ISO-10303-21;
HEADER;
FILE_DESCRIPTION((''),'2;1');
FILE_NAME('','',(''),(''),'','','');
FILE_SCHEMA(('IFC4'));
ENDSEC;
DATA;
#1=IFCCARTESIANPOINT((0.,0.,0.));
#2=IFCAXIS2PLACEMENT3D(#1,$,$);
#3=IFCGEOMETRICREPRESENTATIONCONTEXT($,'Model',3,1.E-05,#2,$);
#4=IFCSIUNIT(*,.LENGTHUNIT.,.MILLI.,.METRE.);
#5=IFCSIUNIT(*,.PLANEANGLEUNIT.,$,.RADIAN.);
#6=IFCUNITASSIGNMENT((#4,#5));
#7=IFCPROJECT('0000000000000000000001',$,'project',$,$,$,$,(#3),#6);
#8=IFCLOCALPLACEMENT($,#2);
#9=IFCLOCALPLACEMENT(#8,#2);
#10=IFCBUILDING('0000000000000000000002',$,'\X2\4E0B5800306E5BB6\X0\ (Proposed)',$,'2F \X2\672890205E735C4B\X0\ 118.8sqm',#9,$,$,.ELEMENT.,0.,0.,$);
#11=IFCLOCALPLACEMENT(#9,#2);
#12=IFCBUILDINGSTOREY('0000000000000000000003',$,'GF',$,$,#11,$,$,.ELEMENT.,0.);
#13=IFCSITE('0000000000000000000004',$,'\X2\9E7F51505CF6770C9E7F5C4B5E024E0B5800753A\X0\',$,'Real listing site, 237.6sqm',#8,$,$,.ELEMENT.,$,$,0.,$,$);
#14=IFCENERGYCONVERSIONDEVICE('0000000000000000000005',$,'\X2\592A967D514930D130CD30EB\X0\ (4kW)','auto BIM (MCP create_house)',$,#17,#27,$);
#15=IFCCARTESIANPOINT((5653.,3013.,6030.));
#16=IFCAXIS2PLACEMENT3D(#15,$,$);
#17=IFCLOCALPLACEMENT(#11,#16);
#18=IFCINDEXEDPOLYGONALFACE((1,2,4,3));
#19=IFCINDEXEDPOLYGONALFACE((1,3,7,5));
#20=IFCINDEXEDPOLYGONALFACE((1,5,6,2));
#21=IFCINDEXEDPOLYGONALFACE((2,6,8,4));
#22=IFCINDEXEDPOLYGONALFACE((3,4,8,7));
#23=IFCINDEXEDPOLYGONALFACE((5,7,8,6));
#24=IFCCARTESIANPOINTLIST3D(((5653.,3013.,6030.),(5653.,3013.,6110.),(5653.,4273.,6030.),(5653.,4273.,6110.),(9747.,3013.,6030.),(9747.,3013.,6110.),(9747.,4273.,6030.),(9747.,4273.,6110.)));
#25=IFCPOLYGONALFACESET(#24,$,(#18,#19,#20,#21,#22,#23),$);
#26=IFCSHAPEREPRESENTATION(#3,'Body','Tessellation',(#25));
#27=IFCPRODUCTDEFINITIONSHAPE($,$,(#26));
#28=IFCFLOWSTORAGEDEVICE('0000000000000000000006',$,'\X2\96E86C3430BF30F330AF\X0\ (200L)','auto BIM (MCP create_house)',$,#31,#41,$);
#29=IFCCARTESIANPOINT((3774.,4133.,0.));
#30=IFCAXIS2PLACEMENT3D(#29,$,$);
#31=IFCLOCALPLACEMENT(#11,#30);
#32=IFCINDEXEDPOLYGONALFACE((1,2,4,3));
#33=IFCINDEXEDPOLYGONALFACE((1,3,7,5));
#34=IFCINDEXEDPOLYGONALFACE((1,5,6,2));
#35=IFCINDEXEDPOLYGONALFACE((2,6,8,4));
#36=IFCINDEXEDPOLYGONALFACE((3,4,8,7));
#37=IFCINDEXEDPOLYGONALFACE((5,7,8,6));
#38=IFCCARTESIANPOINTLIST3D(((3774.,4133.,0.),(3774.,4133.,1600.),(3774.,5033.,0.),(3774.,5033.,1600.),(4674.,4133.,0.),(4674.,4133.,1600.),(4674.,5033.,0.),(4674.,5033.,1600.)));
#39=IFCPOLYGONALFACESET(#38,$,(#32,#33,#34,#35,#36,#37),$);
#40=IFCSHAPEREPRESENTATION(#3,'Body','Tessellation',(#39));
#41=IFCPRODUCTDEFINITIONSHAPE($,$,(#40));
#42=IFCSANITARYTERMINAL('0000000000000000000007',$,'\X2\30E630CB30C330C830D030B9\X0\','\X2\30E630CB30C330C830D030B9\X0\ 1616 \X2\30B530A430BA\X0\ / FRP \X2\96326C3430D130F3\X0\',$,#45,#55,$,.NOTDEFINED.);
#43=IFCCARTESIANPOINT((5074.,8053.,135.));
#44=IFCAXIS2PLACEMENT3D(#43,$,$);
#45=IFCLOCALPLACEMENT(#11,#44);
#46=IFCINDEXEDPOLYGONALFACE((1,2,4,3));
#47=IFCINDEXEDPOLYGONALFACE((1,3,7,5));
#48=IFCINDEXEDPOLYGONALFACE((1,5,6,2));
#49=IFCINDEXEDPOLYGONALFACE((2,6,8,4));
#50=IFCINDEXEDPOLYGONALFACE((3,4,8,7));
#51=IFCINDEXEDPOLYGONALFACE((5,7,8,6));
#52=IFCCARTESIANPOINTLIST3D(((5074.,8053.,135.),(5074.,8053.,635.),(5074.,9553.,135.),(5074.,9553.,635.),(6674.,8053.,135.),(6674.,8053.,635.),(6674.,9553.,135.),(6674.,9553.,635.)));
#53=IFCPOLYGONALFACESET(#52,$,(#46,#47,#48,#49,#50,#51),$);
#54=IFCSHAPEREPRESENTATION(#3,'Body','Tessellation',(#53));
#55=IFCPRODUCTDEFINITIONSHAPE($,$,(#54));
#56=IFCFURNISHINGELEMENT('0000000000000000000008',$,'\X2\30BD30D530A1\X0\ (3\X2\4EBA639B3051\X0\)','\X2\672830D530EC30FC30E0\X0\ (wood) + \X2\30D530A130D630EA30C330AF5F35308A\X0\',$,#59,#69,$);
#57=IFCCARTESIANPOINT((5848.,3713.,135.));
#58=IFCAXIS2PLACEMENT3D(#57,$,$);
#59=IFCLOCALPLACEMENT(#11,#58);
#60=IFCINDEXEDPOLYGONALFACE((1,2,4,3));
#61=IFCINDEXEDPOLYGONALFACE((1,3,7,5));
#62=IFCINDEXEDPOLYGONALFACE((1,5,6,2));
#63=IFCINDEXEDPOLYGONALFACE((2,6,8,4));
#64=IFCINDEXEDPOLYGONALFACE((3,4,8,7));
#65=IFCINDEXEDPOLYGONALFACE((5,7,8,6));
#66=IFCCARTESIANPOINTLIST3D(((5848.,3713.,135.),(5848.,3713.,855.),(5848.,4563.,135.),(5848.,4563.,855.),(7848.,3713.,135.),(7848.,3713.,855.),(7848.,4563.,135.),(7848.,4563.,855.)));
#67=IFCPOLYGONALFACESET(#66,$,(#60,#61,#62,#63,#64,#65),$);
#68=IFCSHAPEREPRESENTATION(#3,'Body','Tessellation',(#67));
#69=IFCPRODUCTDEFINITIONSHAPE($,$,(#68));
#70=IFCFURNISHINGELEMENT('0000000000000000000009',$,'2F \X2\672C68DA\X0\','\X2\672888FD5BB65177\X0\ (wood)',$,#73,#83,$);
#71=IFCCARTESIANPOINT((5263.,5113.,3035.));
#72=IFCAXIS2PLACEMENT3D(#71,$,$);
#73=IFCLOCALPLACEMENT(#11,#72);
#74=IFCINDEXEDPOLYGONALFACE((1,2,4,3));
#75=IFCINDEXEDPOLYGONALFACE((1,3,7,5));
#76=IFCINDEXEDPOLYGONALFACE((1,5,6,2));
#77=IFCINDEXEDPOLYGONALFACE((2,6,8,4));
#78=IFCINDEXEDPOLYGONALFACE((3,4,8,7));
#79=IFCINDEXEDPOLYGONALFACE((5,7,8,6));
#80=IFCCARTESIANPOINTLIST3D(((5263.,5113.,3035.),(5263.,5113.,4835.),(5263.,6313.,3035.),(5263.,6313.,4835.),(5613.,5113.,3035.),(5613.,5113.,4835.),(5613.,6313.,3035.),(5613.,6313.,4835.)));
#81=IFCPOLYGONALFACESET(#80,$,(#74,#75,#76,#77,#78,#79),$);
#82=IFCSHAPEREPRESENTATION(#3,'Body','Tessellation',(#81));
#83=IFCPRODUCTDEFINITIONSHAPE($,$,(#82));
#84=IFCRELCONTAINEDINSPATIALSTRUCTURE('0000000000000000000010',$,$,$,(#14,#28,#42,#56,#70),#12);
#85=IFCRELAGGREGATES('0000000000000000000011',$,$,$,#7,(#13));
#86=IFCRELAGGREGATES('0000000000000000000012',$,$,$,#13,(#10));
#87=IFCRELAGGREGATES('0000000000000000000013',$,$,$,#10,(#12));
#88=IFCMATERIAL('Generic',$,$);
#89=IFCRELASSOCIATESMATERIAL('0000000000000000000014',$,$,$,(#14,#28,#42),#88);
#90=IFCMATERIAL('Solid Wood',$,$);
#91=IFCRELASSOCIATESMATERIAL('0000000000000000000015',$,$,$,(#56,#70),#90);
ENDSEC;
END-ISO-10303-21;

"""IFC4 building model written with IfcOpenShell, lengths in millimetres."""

from ifc_helpers import new_model, si_unit, frame, frame_2d, origin, place, context, project, spatial, rectangle, extrude, material, element, save


model = new_model("IFC4")

# Units and contexts
model_context = context("Model", 3, precision=1e-05, world=origin())
ifc_project = project(units=[si_unit("LENGTHUNIT", "METRE", prefix="MILLI"), si_unit("PLANEANGLEUNIT", "RADIAN")], contexts=[model_context])

# Site, building, storey
site_placement = place(None, origin())
site = spatial("IfcSite", under=ifc_project, at=site_placement, Name="鹿児島県鹿屋市下堀町", ObjectType="Real listing site, 237.6sqm", CompositionType="ELEMENT", RefElevation=0.0)
building_placement = place(site_placement, origin())
building = spatial("IfcBuilding", under=site, at=building_placement, Name="下堀の家 (Proposed)", ObjectType="2F 木造平屋 118.8sqm", CompositionType="ELEMENT", ElevationOfRefHeight=0.0, ElevationOfTerrain=0.0)
storey_placement = place(building_placement, origin())
storey = spatial("IfcBuildingStorey", under=building, at=storey_placement, Name="GF", CompositionType="ELEMENT", Elevation=0.0)

# Shared definitions
ifc_material_1 = material(Name="Solid Wood")

# Energy conversion device
ifc_material_2 = material(Name="Generic")
energy_conversion_device_placement = place(storey_placement, frame((5653.0, 3013.0, 6030.0)))
element("IfcEnergyConversionDevice", 1, at=energy_conversion_device_placement, inside=storey, material=ifc_material_2, Name="太陽光パネル (4kW)", Description="auto BIM (MCP create_house)", context=model_context, shape_type="SweptSolid", body=[
    extrude(rectangle(XDim=4094.0, YDim=1260.0, at=frame_2d((2047.0, 630.0))), frame((5653.0, 3013.0, 6030.0)), (0.0, 0.0, 1.0), 80.0),
])

# Flow storage device
flow_storage_device_placement = place(storey_placement, frame((3774.0, 4133.0, 0.0)))
element("IfcFlowStorageDevice", 2, at=flow_storage_device_placement, inside=storey, material=ifc_material_2, Name="雨水タンク (200L)", Description="auto BIM (MCP create_house)", context=model_context, shape_type="SweptSolid", body=[
    extrude(rectangle(XDim=900.0, YDim=900.0, at=frame_2d((450.0, 450.0))), frame((3774.0, 4133.0, 0.0)), (0.0, 0.0, 1.0), 1600.0),
])

# Sanitary terminal
sanitary_terminal_placement = place(storey_placement, frame((5074.0, 8053.0, 135.0)))
element("IfcSanitaryTerminal", 3, at=sanitary_terminal_placement, inside=storey, material=ifc_material_2, Name="ユニットバス", Description="ユニットバス 1616 サイズ / FRP 防水パン", PredefinedType="NOTDEFINED", context=model_context, shape_type="SweptSolid", body=[
    extrude(rectangle(XDim=1600.0, YDim=1500.0, at=frame_2d((800.0, 750.0))), frame((5074.0, 8053.0, 135.0)), (0.0, 0.0, 1.0), 500.0),
])

# Furnishing elements
furnishing_1_placement = place(storey_placement, frame((5848.0, 3713.0, 135.0)))
element("IfcFurnishingElement", 4, at=furnishing_1_placement, inside=storey, material=ifc_material_1, Name="ソファ (3人掛け)", Description="木フレーム (wood) + ファブリック張り", context=model_context, shape_type="SweptSolid", body=[
    extrude(rectangle(XDim=2000.0, YDim=850.0, at=frame_2d((1000.0, 425.0))), frame((5848.0, 3713.0, 135.0)), (0.0, 0.0, 1.0), 720.0),
])
furnishing_2_placement = place(storey_placement, frame((5263.0, 5113.0, 3035.0)))
element("IfcFurnishingElement", 5, at=furnishing_2_placement, inside=storey, material=ifc_material_1, Name="2F 本棚", Description="木製家具 (wood)", context=model_context, shape_type="SweptSolid", body=[
    extrude(rectangle(XDim=350.0, YDim=1200.0, at=frame_2d((175.0, 600.0))), frame((5263.0, 5113.0, 3035.0)), (0.0, 0.0, 1.0), 1800.0),
])

save(model, "model.ifc")
